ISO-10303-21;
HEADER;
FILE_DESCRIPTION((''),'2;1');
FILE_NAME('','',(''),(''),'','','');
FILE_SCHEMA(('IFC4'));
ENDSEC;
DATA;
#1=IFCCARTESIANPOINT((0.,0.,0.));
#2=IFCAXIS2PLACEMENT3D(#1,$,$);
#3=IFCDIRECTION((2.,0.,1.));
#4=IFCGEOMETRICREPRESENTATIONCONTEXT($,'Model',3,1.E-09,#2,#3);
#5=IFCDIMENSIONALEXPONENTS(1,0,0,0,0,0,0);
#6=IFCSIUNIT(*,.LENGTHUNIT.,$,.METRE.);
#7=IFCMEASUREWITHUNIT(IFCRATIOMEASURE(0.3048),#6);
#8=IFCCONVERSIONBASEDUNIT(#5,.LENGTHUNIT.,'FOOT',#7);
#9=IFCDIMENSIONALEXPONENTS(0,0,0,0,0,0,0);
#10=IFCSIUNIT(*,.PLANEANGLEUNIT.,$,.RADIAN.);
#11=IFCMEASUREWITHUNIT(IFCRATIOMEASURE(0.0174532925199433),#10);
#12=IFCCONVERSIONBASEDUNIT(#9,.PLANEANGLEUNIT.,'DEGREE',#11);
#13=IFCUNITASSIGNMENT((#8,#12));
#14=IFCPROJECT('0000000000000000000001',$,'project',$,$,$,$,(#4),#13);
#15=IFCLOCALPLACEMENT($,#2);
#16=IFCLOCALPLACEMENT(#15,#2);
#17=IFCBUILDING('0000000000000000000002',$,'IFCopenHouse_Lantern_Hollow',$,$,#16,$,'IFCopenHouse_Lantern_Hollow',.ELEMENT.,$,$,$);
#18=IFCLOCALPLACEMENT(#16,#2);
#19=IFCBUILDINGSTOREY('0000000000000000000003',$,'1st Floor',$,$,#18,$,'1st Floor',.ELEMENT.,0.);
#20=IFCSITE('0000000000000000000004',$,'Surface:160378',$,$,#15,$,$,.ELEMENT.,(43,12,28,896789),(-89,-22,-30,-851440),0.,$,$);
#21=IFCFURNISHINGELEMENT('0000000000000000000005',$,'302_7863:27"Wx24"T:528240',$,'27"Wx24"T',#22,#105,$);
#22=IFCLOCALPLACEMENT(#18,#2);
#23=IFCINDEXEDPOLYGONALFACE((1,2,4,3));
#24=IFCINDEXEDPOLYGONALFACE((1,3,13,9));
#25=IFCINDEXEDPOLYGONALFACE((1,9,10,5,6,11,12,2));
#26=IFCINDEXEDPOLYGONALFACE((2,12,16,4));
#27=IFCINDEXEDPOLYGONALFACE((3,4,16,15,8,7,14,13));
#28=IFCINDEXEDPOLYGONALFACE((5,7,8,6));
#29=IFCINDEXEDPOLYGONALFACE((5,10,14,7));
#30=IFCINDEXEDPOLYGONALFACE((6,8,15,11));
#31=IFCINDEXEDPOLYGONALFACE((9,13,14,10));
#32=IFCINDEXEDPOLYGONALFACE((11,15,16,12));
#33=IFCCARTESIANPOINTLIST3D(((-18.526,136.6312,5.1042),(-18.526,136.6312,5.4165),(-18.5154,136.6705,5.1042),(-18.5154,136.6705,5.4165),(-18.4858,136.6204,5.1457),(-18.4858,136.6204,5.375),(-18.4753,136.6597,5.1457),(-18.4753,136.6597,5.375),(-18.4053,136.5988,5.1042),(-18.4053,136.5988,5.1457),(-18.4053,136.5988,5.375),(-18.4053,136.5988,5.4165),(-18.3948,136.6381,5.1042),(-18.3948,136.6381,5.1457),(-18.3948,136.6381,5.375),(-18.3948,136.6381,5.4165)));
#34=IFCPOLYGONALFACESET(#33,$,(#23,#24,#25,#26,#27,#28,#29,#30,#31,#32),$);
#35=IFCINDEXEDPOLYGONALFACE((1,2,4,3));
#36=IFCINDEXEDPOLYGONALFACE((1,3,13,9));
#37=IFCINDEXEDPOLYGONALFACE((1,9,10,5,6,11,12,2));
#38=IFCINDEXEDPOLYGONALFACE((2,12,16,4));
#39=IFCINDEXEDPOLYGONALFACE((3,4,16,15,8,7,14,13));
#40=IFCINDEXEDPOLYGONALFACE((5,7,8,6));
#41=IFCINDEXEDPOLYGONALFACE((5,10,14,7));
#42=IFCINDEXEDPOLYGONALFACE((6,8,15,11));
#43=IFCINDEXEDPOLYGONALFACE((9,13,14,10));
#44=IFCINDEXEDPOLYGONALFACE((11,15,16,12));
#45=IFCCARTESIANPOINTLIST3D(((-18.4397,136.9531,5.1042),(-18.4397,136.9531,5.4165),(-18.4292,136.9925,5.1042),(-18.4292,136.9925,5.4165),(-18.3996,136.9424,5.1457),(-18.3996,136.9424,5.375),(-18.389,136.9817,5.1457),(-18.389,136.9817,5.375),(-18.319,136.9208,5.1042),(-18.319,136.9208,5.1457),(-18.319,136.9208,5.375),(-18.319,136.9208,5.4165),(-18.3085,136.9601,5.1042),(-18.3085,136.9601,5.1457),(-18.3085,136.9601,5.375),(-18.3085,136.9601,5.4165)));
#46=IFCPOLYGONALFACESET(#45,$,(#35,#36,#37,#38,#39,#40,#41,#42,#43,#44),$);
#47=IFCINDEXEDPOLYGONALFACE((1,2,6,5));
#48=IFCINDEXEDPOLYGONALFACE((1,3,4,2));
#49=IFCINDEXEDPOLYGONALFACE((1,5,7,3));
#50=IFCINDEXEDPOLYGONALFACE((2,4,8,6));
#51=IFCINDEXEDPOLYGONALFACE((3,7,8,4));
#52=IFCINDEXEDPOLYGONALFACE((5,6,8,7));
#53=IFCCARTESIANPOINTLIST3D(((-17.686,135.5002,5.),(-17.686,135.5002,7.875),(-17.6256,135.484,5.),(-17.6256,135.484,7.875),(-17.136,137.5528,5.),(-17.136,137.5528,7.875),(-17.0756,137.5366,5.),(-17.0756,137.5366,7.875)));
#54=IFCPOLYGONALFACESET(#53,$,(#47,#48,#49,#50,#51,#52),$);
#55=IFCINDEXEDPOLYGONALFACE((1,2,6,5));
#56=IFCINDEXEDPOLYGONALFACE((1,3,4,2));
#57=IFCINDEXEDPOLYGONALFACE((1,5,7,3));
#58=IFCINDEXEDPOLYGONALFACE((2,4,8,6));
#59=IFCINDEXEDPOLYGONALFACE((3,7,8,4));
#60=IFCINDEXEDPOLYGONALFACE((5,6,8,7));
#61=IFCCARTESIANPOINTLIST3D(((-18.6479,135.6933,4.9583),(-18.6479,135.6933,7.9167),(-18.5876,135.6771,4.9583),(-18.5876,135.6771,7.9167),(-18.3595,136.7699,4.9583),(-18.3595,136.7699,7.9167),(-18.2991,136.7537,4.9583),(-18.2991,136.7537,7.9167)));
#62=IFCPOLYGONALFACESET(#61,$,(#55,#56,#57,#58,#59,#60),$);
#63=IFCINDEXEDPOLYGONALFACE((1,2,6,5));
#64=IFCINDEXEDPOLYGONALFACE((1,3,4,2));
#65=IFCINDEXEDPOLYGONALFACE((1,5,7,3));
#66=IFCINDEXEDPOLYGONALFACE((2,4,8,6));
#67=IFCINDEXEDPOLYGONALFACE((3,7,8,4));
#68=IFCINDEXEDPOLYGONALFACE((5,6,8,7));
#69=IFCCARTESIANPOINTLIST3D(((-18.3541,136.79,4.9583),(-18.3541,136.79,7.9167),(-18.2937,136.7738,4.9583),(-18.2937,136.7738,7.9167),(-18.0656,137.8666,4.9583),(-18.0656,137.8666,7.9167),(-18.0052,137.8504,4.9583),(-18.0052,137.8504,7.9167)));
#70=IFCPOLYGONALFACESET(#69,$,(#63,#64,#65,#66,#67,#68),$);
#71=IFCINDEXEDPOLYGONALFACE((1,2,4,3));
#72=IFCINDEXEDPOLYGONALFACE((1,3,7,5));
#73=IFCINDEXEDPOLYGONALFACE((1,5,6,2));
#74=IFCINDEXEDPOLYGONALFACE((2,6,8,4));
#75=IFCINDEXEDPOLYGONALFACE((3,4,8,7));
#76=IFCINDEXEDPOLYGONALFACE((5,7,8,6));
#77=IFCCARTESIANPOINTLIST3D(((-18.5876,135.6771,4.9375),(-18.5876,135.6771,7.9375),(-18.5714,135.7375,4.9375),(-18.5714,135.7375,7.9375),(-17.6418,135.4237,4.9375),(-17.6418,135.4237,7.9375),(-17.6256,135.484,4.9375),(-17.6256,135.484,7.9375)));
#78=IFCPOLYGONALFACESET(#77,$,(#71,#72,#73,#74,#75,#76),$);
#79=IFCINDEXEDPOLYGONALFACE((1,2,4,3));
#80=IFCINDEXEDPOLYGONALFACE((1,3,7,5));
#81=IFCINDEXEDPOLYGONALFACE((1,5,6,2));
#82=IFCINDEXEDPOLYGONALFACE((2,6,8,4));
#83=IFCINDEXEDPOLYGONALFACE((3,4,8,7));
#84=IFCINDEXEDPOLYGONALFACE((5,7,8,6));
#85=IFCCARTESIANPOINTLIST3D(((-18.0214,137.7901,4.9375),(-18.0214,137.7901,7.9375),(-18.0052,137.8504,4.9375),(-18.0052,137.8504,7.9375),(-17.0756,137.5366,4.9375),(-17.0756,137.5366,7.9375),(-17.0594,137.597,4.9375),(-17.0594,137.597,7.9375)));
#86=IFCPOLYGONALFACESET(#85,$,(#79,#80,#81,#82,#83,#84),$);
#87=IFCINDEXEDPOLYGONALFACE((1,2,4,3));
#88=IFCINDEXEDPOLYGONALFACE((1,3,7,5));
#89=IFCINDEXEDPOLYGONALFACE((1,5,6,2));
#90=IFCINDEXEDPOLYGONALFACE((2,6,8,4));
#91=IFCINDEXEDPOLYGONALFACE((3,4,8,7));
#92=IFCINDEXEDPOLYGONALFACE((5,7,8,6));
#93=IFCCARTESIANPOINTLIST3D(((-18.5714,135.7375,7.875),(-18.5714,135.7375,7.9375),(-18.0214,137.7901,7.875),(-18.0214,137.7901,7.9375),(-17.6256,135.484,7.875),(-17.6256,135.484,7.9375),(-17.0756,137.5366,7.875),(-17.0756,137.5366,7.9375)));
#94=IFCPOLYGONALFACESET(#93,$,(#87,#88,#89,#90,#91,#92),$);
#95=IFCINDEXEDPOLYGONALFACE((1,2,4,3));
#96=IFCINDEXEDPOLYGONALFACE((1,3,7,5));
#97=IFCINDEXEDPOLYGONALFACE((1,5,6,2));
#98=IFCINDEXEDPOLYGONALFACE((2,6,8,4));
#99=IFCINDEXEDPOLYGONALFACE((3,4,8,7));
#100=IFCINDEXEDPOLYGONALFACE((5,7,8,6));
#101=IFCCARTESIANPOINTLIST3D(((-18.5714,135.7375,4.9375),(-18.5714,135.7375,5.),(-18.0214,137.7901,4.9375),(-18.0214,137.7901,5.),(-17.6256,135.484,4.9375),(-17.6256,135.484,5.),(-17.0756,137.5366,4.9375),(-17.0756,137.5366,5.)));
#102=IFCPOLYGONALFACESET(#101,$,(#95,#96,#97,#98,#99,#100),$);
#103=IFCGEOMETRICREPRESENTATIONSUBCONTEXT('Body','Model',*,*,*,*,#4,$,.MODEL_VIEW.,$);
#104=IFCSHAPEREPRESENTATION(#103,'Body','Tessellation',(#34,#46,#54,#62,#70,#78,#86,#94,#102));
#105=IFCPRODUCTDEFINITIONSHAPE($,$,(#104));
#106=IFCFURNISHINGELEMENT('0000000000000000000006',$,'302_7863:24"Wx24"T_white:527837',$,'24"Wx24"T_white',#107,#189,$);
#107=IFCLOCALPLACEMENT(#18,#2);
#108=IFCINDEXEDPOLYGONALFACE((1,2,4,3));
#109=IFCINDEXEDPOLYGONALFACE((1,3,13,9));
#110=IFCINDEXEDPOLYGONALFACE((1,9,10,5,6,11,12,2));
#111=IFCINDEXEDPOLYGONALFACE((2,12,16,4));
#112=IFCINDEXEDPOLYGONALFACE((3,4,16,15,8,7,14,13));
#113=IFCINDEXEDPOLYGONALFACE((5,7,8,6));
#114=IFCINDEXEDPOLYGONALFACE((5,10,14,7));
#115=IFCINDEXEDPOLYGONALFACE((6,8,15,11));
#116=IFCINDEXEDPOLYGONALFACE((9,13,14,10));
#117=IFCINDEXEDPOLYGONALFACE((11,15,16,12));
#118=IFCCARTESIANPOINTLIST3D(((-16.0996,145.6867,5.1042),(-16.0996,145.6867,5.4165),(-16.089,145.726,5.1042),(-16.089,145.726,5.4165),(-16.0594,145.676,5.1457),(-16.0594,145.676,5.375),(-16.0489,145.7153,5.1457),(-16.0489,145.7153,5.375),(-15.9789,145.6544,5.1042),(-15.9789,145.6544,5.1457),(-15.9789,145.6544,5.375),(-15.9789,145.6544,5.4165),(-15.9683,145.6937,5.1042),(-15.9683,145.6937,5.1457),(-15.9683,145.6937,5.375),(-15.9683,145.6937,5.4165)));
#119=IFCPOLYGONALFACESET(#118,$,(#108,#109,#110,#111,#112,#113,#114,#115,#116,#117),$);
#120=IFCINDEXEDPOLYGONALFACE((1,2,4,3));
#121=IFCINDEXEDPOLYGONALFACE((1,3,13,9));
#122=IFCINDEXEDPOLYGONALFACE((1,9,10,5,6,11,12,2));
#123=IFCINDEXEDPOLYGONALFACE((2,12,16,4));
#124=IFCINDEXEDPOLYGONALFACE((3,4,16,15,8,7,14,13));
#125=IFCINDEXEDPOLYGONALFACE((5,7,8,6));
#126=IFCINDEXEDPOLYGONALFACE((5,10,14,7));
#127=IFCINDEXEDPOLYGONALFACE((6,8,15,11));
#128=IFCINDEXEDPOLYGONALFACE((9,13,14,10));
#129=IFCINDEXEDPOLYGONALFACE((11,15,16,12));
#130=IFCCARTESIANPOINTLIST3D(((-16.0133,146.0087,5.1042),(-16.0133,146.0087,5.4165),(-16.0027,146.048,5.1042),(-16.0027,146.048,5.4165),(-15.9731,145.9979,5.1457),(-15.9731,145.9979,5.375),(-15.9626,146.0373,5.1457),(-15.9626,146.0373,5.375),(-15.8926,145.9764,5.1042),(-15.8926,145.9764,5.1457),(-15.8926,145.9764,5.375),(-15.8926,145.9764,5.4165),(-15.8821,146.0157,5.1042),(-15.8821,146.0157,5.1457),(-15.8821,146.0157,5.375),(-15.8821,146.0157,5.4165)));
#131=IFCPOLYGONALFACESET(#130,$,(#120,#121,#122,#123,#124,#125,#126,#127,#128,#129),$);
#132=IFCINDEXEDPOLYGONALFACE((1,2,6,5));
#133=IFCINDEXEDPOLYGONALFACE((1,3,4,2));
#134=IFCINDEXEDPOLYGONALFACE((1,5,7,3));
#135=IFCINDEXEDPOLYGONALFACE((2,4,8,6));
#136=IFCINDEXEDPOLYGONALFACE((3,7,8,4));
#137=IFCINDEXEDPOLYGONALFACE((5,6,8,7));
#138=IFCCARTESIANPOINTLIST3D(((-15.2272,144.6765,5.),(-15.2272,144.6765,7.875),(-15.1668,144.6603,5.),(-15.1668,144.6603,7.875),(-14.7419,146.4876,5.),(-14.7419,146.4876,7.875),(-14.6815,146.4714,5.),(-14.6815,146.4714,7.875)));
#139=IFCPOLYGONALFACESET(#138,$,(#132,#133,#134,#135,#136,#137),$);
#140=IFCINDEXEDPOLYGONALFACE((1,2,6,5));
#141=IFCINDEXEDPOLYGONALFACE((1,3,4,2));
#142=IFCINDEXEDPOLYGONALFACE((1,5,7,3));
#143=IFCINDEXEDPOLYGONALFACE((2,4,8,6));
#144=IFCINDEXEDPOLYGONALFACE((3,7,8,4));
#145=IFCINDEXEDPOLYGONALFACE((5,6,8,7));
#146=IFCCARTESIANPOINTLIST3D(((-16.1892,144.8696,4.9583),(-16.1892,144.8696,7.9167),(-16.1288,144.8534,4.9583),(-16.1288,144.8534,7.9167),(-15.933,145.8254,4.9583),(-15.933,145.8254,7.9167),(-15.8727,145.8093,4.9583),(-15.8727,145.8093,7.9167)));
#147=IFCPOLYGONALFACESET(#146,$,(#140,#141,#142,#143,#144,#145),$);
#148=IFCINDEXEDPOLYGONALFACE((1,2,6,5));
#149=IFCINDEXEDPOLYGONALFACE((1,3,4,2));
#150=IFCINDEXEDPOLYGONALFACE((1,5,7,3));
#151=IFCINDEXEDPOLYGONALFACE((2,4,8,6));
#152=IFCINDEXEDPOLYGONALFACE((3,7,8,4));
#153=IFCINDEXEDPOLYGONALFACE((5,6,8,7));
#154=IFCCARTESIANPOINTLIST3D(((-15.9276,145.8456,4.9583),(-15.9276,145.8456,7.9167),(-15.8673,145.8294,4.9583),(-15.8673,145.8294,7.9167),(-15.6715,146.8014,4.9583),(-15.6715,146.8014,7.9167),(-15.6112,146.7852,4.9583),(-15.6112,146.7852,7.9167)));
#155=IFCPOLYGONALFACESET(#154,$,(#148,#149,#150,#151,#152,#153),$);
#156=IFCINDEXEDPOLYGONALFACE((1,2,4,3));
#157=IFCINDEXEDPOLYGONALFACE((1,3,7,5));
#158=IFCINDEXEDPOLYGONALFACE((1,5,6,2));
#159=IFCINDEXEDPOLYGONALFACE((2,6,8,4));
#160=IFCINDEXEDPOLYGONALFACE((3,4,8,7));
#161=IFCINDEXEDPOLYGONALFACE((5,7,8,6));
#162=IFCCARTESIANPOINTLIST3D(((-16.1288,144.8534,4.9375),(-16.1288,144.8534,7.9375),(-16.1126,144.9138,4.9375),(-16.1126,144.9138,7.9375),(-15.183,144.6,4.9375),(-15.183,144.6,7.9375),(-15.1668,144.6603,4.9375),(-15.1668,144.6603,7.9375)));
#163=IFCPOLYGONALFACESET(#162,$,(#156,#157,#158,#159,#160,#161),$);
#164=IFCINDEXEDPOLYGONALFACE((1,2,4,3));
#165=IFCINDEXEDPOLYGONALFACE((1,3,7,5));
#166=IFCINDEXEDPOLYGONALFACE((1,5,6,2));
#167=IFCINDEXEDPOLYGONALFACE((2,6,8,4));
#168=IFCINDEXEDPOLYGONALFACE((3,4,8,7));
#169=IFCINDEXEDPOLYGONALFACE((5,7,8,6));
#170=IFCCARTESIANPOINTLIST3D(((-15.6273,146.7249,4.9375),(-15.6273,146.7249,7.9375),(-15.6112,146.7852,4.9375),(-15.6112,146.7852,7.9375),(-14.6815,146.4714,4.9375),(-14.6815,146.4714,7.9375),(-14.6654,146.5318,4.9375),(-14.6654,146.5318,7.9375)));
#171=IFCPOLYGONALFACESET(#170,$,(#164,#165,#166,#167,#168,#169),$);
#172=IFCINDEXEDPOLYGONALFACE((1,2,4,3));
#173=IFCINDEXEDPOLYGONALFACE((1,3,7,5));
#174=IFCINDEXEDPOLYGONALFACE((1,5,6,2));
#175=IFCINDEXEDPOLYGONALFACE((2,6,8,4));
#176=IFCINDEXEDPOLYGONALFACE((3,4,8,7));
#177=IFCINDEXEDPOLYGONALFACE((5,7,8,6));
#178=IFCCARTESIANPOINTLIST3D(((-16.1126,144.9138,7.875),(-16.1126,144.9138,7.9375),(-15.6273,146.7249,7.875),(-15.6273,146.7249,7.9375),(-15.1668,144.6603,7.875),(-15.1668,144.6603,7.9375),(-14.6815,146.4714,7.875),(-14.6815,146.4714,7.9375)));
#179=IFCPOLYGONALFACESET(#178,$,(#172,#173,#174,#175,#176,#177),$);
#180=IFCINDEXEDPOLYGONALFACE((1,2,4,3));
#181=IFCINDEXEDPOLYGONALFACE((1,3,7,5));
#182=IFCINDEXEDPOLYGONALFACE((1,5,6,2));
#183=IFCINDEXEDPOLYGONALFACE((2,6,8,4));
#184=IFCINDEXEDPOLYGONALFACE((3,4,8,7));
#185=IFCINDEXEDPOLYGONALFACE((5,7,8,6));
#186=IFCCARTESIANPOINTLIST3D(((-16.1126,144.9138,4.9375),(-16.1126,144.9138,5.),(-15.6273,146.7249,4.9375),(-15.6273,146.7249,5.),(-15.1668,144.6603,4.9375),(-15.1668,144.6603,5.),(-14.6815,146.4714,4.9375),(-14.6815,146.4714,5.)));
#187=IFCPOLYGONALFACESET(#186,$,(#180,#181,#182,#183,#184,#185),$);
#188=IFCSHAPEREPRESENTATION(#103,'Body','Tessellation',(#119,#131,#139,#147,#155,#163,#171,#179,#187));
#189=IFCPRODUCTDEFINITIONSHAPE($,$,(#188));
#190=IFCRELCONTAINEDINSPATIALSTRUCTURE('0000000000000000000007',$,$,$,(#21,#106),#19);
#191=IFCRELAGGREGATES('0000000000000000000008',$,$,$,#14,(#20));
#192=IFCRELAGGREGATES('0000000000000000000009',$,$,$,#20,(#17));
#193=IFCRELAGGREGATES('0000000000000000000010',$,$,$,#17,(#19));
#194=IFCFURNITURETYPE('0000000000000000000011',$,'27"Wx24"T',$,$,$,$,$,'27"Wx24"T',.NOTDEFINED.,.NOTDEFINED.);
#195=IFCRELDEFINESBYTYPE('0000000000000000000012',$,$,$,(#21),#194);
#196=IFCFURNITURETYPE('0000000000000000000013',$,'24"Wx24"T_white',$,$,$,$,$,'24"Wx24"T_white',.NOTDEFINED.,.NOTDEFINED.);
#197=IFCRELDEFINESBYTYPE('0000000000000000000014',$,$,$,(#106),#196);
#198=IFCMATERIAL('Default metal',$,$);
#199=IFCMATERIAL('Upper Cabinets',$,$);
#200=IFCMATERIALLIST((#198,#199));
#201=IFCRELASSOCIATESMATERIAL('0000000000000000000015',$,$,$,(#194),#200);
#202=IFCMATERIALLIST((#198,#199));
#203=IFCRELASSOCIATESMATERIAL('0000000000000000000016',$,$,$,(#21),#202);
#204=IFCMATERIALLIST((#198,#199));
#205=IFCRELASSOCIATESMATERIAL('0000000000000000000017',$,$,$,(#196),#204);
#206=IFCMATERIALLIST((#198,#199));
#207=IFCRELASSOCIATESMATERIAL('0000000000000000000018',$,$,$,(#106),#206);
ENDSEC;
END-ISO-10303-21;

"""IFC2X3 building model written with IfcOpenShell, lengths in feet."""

from ifc_helpers import new_model, entity, si_unit, converted_unit, direction, frame, frame_2d, origin, origin_2d_with_axis, place, context, subcontext, project, spatial, polyline, rectangle, outline, extrude, source, transform, mapped, material, material_list, type_object, type_shapes, element, save


model = new_model("IFC2X3")

# Units and contexts
model_context = context("Model", 3, precision=1e-09, world=origin(), true_north=direction((2.0, 0.0, 1.0)))
body_context = subcontext(model_context, "Body", "Model", "MODEL_VIEW")
ifc_project = project(units=[converted_unit("LENGTHUNIT", "FOOT", entity("IfcRatioMeasure", 0.3048), si_unit("LENGTHUNIT", "METRE"), dimensions=[1, 0, 0, 0, 0, 0, 0]), converted_unit("PLANEANGLEUNIT", "DEGREE", entity("IfcRatioMeasure", 0.0174532925199433), si_unit("PLANEANGLEUNIT", "RADIAN"), dimensions=[0, 0, 0, 0, 0, 0, 0])], contexts=[model_context])

# Site, building, storey
site_placement = place(None, origin())
site = spatial("IfcSite", under=ifc_project, at=site_placement, Name="Surface:160378", CompositionType="ELEMENT", RefLatitude=(43, 12, 28, 896789), RefLongitude=(-89, -22, -30, -851440), RefElevation=0.0)
building_placement = place(site_placement, origin())
building = spatial("IfcBuilding", under=site, at=building_placement, Name="IFCopenHouse_Lantern_Hollow", LongName="IFCopenHouse_Lantern_Hollow", CompositionType="ELEMENT")
storey_placement = place(building_placement, origin())
storey = spatial("IfcBuildingStorey", under=building, at=storey_placement, Name="1st Floor", LongName="1st Floor", CompositionType="ELEMENT", Elevation=0.0)

# Furnishing elements
ifc_material_1 = material(Name="Default metal")
ifc_material_2 = material(Name="Upper Cabinets")
ifc_material_list_1 = material_list([ifc_material_1, ifc_material_2])
furniture_type_1 = type_object("IfcFurnitureType", Name="27\"Wx24\"T", ElementType="27\"Wx24\"T", AssemblyPlace="NOTDEFINED", material=ifc_material_list_1)
shared_shape_1 = source(origin(), body_context, "Body", "SweptSolid", [
    extrude(outline(polyline([(-0.0521, -0.1146), (-0.0521, -0.1562), (0.0729, -0.1562), (0.0729, 0.1562), (-0.0521, 0.1562), (-0.0521, 0.1146), (0.0313, 0.1146), (0.0313, -0.1146), (-0.0521, -0.1146)])), frame((0.9375, 1.0937, 0.3229), z_axis=(-1.0, 0.0, 0.0), x_axis=(0.0, 1.0, 0.0)), (0.0, 0.0, -1.0), 0.0407),
    extrude(outline(polyline([(-0.0521, -0.1146), (-0.0521, -0.1562), (0.0729, -0.1562), (0.0729, 0.1562), (-0.0521, 0.1562), (-0.0521, 0.1146), (0.0313, 0.1146), (0.0313, -0.1146), (-0.0521, -0.1146)])), frame((1.2708, 1.0937, 0.3229), z_axis=(-1.0, 0.0, 0.0), x_axis=(0.0, 1.0, 0.0)), (0.0, 0.0, -1.0), 0.0407),
    extrude(rectangle(XDim=0.0625, YDim=2.125, at=frame_2d((0.0, 0.0), x_axis=(1.0, 0.0))), frame((1.125, 0.0313, 0.0625), z_axis=(0.0, 0.0, 1.0), x_axis=(0.0, 1.0, 0.0)), (0.0, 0.0, 1.0), 2.875),
    extrude(rectangle(XDim=0.0625, YDim=1.1146, at=origin_2d_with_axis()), frame((0.5573, 1.0104, 0.0208), z_axis=(0.0, 0.0, 1.0), x_axis=(0.0, 1.0, 0.0)), (0.0, 0.0, 1.0), 2.9583),
    extrude(rectangle(XDim=0.0625, YDim=1.1146, at=frame_2d((0.0, 0.0), x_axis=(1.0, 0.0))), frame((1.6927, 1.0104, 0.0208), z_axis=(0.0, 0.0, 1.0), x_axis=(0.0, 1.0, 0.0)), (0.0, 0.0, 1.0), 2.9583),
    extrude(rectangle(XDim=0.0625, YDim=0.9792, at=frame_2d((0.0, 0.0), x_axis=(1.0, 0.0))), frame((0.0313, 0.4896, 0.0)), (0.0, 0.0, 1.0), 3.0),
    extrude(rectangle(XDim=0.0625, YDim=0.9792, at=origin_2d_with_axis()), frame((2.2188, 0.4896, 0.0)), (0.0, 0.0, 1.0), 3.0),
    extrude(rectangle(XDim=2.125, YDim=0.9792, at=origin_2d_with_axis()), frame((1.125, 0.4896, 2.9375), z_axis=(0.0, 0.0, 1.0), x_axis=(-1.0, 0.0, 0.0)), (0.0, 0.0, 1.0), 0.0625),
    extrude(rectangle(XDim=2.125, YDim=0.9792, at=frame_2d((0.0, 0.0), x_axis=(1.0, 0.0))), frame((1.125, 0.4896, 0.0), z_axis=(0.0, 0.0, 1.0), x_axis=(-1.0, 0.0, 0.0)), (0.0, 0.0, 1.0), 0.0625),
])
type_shapes(furniture_type_1, [shared_shape_1])
ifc_material_list_2 = material_list([ifc_material_1, ifc_material_2])
furnishing_1_placement = place(storey_placement, frame((-17.6418, 135.4237, 4.9375), z_axis=(0.0, 0.0, 1.0), x_axis=(0.258819, 0.965926, 0.0)))
element("IfcFurnishingElement", 1, at=furnishing_1_placement, inside=storey, type_object=furniture_type_1, material=ifc_material_list_2, Name="302_7863:27\"Wx24\"T:528240", ObjectType="27\"Wx24\"T", context=body_context, shape_type="MappedRepresentation", body=[
    mapped(shared_shape_1, transform((0.0, 0.0, 0.0), scale=1.0)),
])
ifc_material_list_3 = material_list([ifc_material_1, ifc_material_2])
ifc_material_list_4 = material_list([ifc_material_1, ifc_material_2])
furniture_type_2 = type_object("IfcFurnitureType", Name="24\"Wx24\"T_white", ElementType="24\"Wx24\"T_white", AssemblyPlace="NOTDEFINED", material=ifc_material_list_4)
shared_shape_2 = source(origin(), body_context, "Body", "SweptSolid", [
    extrude(outline(polyline([(-0.0521, -0.1146), (-0.0521, -0.1562), (0.0729, -0.1562), (0.0729, 0.1562), (-0.0521, 0.1562), (-0.0521, 0.1146), (0.0313, 0.1146), (0.0313, -0.1146), (-0.0521, -0.1146)])), frame((0.8125, 1.0937, 0.3229), z_axis=(-1.0, 0.0, 0.0), x_axis=(0.0, 1.0, 0.0)), (0.0, 0.0, -1.0), 0.0407),
    extrude(outline(polyline([(-0.0521, -0.1146), (-0.0521, -0.1562), (0.0729, -0.1562), (0.0729, 0.1562), (-0.0521, 0.1562), (-0.0521, 0.1146), (0.0313, 0.1146), (0.0313, -0.1146), (-0.0521, -0.1146)])), frame((1.1458, 1.0937, 0.3229), z_axis=(-1.0, 0.0, 0.0), x_axis=(0.0, 1.0, 0.0)), (0.0, 0.0, -1.0), 0.0407),
    extrude(rectangle(XDim=0.0625, YDim=1.875, at=frame_2d((0.0, 0.0), x_axis=(1.0, 0.0))), frame((1.0, 0.0313, 0.0625), z_axis=(0.0, 0.0, 1.0), x_axis=(0.0, 1.0, 0.0)), (0.0, 0.0, 1.0), 2.875),
    extrude(rectangle(XDim=0.0625, YDim=0.9896, at=frame_2d((0.0, 0.0), x_axis=(1.0, 0.0))), frame((0.4948, 1.0104, 0.0208), z_axis=(0.0, 0.0, 1.0), x_axis=(0.0, 1.0, 0.0)), (0.0, 0.0, 1.0), 2.9583),
    extrude(rectangle(XDim=0.0625, YDim=0.9896, at=frame_2d((0.0, 0.0), x_axis=(1.0, 0.0))), frame((1.5052, 1.0104, 0.0208), z_axis=(0.0, 0.0, 1.0), x_axis=(0.0, 1.0, 0.0)), (0.0, 0.0, 1.0), 2.9583),
    extrude(rectangle(XDim=0.0625, YDim=0.9792, at=frame_2d((0.0, 0.0), x_axis=(1.0, 0.0))), frame((0.0313, 0.4896, 0.0)), (0.0, 0.0, 1.0), 3.0),
    extrude(rectangle(XDim=0.0625, YDim=0.9792, at=frame_2d((0.0, 0.0), x_axis=(1.0, 0.0))), frame((1.9688, 0.4896, 0.0)), (0.0, 0.0, 1.0), 3.0),
    extrude(rectangle(XDim=1.875, YDim=0.9792, at=origin_2d_with_axis()), frame((1.0, 0.4896, 2.9375), z_axis=(0.0, 0.0, 1.0), x_axis=(-1.0, 0.0, 0.0)), (0.0, 0.0, 1.0), 0.0625),
    extrude(rectangle(XDim=1.875, YDim=0.9792, at=frame_2d((0.0, 0.0), x_axis=(1.0, 0.0))), frame((1.0, 0.4896, 0.0), z_axis=(0.0, 0.0, 1.0), x_axis=(-1.0, 0.0, 0.0)), (0.0, 0.0, 1.0), 0.0625),
])
type_shapes(furniture_type_2, [shared_shape_2])
furnishing_2_placement = place(storey_placement, frame((-15.183, 144.6, 4.9375), z_axis=(0.0, 0.0, 1.0), x_axis=(0.258819, 0.965926, 0.0)))
element("IfcFurnishingElement", 2, at=furnishing_2_placement, inside=storey, type_object=furniture_type_2, material=ifc_material_list_3, Name="302_7863:24\"Wx24\"T_white:527837", ObjectType="24\"Wx24\"T_white", context=body_context, shape_type="MappedRepresentation", body=[
    mapped(shared_shape_2, transform((0.0, 0.0, 0.0), scale=1.0)),
])

save(model, "model.ifc")
